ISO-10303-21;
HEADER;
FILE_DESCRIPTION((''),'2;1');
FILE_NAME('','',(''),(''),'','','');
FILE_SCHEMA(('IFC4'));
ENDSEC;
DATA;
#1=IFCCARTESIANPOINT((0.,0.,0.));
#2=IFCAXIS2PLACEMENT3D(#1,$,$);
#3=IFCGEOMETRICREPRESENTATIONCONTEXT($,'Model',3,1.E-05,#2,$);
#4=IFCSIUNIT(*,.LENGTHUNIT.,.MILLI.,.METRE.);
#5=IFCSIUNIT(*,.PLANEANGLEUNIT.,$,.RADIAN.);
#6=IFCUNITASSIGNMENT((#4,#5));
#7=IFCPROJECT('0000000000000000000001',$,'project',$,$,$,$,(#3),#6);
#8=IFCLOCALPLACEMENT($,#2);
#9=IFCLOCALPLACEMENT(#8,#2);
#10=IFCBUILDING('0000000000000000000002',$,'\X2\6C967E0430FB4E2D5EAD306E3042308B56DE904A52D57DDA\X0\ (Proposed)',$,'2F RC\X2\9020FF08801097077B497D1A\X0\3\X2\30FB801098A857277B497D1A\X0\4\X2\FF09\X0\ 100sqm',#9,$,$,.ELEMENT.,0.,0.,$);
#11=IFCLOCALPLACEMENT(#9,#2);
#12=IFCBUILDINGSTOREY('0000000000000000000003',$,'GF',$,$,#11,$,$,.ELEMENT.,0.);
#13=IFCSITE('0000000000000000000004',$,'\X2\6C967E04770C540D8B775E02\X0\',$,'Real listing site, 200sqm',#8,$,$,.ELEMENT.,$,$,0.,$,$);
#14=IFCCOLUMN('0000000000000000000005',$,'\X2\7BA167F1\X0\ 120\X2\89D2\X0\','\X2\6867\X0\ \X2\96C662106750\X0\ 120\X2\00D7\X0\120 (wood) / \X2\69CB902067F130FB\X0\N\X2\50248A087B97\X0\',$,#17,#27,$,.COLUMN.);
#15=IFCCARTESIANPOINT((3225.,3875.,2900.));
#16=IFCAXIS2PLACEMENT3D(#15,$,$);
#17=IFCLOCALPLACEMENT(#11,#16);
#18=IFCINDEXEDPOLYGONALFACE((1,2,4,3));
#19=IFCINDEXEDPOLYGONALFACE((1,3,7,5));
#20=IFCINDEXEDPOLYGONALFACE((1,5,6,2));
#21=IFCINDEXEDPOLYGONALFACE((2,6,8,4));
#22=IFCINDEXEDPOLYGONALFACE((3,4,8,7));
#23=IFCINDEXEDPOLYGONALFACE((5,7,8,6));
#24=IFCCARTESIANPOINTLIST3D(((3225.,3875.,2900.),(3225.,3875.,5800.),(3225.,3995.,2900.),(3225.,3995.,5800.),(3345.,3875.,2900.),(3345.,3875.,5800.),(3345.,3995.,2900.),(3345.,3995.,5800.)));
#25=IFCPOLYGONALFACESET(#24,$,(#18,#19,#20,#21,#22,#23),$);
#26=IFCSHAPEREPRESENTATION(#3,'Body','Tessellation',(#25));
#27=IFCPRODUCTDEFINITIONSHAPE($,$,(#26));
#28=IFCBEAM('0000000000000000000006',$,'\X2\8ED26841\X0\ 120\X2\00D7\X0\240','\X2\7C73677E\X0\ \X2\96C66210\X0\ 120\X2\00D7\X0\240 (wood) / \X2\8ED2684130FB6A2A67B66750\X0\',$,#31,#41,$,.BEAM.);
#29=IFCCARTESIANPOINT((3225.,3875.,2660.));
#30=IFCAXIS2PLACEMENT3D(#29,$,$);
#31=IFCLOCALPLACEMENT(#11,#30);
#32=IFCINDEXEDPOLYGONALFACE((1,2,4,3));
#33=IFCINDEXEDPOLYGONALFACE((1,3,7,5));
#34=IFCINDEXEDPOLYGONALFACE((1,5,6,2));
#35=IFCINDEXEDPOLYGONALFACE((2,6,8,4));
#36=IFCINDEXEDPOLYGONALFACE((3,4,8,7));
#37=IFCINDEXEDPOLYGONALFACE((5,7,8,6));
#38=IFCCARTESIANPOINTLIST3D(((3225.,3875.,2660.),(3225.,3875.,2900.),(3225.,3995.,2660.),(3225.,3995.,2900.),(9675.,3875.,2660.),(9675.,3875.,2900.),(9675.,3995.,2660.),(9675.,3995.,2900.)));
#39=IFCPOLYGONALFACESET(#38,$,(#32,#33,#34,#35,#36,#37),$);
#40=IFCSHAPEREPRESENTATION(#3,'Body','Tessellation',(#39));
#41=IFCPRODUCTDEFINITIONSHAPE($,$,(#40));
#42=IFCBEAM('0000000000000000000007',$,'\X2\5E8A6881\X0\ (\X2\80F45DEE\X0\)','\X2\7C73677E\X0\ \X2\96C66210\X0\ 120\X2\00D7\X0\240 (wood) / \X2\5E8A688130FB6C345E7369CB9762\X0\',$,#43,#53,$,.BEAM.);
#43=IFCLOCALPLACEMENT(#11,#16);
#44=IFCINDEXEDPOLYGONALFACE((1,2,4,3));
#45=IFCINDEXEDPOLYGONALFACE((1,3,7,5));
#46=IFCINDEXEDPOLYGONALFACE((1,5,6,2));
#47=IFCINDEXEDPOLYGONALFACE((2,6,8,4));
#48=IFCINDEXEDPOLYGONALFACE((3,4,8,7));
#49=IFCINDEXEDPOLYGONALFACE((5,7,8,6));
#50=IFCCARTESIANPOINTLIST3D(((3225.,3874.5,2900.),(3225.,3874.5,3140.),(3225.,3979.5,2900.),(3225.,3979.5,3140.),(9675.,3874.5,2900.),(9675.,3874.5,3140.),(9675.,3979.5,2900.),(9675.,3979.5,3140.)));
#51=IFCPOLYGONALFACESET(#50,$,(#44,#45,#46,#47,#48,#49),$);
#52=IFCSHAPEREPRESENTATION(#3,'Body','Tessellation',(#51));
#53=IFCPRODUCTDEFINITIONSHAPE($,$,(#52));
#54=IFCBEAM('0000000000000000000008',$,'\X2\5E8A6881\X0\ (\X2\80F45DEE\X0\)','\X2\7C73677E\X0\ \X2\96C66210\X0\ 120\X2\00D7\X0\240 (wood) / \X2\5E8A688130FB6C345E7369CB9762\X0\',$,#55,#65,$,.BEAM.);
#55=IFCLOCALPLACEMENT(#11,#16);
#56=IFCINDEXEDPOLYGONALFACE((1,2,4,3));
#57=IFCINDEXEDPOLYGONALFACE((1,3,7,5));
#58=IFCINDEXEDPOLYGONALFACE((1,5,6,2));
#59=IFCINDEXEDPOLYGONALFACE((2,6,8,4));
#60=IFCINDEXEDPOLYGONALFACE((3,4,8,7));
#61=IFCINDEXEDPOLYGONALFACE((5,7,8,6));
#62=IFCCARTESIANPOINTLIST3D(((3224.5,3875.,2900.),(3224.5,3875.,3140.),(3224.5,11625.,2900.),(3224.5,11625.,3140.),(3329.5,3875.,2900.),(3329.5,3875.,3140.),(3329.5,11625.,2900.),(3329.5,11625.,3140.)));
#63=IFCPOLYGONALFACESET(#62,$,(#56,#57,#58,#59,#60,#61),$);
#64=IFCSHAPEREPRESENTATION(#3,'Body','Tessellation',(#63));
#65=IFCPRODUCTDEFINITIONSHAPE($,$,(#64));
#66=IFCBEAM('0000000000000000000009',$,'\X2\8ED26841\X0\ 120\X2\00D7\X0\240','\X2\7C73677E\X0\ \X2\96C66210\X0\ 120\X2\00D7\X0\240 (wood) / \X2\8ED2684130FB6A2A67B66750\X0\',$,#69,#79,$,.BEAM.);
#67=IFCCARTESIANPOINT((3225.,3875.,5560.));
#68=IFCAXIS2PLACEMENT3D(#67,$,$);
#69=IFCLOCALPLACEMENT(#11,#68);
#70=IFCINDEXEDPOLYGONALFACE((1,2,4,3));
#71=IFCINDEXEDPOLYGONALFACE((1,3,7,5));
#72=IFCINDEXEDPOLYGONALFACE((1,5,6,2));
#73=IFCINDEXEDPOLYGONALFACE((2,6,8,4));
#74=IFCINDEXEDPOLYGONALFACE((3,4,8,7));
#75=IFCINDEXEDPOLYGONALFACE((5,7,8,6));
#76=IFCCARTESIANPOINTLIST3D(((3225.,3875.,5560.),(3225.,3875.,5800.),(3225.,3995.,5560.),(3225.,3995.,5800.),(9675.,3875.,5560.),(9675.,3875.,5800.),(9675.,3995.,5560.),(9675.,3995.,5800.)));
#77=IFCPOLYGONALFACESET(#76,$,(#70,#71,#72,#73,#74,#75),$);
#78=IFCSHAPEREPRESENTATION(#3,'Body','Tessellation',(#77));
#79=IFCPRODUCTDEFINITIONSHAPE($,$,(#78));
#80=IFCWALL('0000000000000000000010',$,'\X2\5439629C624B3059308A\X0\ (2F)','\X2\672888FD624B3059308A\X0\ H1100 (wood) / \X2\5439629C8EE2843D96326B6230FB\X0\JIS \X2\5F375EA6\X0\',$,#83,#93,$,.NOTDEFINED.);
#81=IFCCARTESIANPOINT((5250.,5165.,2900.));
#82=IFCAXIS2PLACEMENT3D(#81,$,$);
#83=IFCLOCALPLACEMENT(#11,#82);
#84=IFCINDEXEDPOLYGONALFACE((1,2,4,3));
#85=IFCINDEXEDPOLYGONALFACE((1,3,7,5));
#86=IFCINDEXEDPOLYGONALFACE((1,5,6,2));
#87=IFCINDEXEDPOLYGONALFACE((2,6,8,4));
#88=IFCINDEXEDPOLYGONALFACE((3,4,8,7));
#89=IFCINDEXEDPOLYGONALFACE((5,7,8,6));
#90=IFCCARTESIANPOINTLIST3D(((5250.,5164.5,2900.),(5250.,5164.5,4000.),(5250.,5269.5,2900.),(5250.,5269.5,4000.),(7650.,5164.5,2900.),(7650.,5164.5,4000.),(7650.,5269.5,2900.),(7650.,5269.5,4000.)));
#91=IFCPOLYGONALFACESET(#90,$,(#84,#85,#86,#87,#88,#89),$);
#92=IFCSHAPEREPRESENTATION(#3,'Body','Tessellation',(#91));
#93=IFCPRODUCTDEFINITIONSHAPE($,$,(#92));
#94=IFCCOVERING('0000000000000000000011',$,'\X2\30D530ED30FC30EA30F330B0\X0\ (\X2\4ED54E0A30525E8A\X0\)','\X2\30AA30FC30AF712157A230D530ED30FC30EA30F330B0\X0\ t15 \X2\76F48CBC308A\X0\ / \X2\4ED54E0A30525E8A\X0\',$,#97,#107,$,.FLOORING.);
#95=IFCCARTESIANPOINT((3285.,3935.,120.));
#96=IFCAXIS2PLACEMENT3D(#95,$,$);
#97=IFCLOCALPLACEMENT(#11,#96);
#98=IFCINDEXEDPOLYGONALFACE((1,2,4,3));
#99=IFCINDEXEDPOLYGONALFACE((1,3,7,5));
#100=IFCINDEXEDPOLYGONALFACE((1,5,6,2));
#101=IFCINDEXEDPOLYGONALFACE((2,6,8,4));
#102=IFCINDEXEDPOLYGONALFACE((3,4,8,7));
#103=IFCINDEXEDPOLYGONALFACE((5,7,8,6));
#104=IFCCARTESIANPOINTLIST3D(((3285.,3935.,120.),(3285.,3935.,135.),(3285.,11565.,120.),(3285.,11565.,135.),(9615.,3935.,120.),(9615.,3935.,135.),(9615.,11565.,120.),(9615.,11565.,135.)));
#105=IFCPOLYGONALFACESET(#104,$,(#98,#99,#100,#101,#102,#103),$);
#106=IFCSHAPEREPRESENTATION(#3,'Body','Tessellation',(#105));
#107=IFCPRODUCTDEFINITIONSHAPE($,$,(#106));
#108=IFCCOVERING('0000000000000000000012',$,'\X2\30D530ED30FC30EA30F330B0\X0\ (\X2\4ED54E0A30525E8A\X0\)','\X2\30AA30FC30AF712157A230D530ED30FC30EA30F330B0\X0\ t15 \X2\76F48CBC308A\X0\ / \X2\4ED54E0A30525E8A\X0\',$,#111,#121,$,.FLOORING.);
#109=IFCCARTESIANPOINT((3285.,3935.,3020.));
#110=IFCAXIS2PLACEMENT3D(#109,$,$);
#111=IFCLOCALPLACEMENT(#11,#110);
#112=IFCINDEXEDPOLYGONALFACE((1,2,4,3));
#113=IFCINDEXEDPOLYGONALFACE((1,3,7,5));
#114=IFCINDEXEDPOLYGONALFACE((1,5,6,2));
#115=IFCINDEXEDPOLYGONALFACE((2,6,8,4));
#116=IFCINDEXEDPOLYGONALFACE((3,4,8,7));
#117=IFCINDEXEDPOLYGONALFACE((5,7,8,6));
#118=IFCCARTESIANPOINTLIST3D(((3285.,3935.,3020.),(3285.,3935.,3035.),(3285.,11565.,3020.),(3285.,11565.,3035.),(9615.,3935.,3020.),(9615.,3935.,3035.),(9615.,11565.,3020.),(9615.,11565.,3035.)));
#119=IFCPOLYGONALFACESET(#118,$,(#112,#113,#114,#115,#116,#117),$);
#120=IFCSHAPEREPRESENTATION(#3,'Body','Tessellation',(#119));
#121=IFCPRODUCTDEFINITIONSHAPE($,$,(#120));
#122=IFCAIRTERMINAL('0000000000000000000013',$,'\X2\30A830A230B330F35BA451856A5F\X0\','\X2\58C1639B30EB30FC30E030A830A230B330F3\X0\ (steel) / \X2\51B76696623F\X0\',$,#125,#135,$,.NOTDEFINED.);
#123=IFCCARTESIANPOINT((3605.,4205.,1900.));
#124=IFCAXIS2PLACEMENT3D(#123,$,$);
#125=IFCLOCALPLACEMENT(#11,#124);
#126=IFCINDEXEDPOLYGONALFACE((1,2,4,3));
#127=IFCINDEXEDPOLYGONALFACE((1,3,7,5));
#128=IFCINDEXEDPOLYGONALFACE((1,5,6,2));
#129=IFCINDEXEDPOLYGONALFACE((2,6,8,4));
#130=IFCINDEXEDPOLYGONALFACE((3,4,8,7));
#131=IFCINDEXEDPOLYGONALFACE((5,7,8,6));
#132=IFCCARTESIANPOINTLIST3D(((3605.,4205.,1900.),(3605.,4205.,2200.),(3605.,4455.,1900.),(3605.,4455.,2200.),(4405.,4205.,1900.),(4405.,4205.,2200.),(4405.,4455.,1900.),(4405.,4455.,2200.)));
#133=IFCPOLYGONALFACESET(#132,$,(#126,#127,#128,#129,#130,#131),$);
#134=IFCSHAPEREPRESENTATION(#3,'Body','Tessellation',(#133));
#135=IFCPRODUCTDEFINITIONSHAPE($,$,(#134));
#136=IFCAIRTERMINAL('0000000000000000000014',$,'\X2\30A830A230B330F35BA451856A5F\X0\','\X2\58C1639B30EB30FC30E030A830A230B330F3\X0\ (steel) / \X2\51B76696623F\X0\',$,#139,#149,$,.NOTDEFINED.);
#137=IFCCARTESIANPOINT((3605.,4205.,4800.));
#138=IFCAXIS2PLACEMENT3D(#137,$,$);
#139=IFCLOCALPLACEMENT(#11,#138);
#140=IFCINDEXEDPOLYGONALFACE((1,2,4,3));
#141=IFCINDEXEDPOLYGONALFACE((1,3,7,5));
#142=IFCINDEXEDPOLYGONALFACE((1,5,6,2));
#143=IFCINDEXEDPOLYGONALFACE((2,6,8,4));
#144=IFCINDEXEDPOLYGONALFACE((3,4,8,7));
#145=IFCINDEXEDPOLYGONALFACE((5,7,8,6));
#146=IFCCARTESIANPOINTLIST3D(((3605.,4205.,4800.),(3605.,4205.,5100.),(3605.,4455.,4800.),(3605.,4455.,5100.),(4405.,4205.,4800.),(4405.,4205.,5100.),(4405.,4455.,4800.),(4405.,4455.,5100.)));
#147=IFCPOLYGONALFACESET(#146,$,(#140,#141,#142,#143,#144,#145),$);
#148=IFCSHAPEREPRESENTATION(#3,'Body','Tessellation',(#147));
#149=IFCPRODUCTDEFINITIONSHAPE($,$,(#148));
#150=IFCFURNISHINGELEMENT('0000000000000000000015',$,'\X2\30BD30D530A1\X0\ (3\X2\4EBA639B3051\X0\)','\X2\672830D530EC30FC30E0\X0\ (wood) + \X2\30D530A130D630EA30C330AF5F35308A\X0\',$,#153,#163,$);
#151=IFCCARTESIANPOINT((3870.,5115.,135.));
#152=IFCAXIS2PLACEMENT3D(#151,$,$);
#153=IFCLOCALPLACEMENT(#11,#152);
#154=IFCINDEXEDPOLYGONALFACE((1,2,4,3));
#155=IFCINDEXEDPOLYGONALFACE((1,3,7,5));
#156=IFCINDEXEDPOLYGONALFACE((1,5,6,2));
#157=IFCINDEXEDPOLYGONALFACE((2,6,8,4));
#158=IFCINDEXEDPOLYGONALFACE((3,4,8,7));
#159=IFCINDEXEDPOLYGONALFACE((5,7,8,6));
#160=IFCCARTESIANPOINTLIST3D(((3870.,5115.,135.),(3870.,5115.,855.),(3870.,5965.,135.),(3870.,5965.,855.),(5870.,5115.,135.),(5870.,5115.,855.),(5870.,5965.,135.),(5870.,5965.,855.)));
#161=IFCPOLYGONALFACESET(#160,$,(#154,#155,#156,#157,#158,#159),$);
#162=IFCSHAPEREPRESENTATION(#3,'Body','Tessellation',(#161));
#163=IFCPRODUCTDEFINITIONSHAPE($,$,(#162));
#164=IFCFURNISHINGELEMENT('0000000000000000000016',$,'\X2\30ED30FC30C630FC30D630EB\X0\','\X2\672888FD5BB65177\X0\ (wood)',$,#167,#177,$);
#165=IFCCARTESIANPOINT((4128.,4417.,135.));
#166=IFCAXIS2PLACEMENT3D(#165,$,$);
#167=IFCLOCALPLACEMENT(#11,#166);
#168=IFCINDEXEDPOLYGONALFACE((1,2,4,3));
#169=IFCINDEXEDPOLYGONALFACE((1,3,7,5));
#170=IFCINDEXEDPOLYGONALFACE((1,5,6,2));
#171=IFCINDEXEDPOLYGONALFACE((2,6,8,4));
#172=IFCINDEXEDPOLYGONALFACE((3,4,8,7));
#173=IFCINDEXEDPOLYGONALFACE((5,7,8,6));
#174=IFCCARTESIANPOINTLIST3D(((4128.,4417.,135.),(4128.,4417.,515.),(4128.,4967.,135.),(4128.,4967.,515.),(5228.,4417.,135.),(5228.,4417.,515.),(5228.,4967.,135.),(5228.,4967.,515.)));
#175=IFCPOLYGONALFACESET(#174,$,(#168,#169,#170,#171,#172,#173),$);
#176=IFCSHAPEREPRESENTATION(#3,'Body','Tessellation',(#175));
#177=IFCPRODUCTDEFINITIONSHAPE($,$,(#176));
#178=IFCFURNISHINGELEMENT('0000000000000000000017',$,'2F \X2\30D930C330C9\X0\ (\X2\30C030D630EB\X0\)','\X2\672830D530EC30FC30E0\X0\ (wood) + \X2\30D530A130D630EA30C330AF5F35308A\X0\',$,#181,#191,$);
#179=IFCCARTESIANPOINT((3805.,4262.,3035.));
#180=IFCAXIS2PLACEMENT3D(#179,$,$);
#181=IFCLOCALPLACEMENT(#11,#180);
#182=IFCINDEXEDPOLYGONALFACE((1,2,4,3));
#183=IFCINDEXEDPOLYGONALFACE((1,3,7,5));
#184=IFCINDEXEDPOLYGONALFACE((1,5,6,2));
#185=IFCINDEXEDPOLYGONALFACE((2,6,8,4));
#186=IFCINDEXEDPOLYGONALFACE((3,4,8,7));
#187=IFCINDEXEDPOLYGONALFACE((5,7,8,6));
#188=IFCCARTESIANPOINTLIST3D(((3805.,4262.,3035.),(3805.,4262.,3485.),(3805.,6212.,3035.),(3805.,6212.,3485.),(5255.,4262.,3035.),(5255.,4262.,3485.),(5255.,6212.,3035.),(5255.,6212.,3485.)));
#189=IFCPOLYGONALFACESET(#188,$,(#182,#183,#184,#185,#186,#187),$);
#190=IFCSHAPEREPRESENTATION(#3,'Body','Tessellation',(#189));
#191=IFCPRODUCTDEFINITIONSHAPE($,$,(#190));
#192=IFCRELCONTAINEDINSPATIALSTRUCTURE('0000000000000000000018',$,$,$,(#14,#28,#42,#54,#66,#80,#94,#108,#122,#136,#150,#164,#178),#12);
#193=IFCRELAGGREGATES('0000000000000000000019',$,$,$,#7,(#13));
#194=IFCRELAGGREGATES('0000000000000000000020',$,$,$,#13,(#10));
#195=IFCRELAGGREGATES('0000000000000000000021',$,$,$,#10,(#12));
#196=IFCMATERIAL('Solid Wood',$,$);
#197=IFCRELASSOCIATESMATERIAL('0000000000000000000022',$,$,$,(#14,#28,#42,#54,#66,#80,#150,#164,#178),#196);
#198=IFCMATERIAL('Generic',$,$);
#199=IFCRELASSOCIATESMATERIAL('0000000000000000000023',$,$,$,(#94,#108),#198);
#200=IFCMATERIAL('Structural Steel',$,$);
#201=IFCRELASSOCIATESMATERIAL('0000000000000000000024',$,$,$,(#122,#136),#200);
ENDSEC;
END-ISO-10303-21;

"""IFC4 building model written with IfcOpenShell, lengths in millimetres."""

from ifc_helpers import new_model, si_unit, frame, frame_2d, origin, place, context, project, spatial, rectangle, extrude, material, element, save


model = new_model("IFC4")

# Units and contexts
model_context = context("Model", 3, precision=1e-05, world=origin())
ifc_project = project(units=[si_unit("LENGTHUNIT", "METRE", prefix="MILLI"), si_unit("PLANEANGLEUNIT", "RADIAN")], contexts=[model_context])

# Site, building, storey
site_placement = place(None, origin())
site = spatial("IfcSite", under=ifc_project, at=site_placement, Name="沖縄県名護市", ObjectType="Real listing site, 200sqm", CompositionType="ELEMENT", RefElevation=0.0)
building_placement = place(site_placement, origin())
building = spatial("IfcBuilding", under=site, at=building_placement, Name="沖縄・中庭のある回遊動線 (Proposed)", ObjectType="2F RC造（耐震等級3・耐風圧等級4） 100sqm", CompositionType="ELEMENT", ElevationOfRefHeight=0.0, ElevationOfTerrain=0.0)
storey_placement = place(building_placement, origin())
storey = spatial("IfcBuildingStorey", under=building, at=storey_placement, Name="GF", CompositionType="ELEMENT", Elevation=0.0)

# Column
ifc_material_1 = material(Name="Solid Wood")
column_placement = place(storey_placement, frame((3225.0, 3875.0, 2900.0)))
element("IfcColumn", 1, at=column_placement, inside=storey, material=ifc_material_1, Name="管柱 120角", Description="桧 集成材 120×120 (wood) / 構造柱・N値計算", PredefinedType="COLUMN", context=model_context, shape_type="SweptSolid", body=[
    extrude(rectangle(XDim=120.0, YDim=120.0, at=frame_2d((60.0, 60.0))), frame((3225.0, 3875.0, 2900.0)), (0.0, 0.0, 1.0), 2900.0),
])

# Beams
beam_1_placement = place(storey_placement, frame((3225.0, 3875.0, 2660.0)))
element("IfcBeam", 2, at=beam_1_placement, inside=storey, material=ifc_material_1, Name="軒桁 120×240", Description="米松 集成 120×240 (wood) / 軒桁・横架材", PredefinedType="BEAM", context=model_context, shape_type="SweptSolid", body=[
    extrude(rectangle(XDim=6450.0, YDim=120.0, at=frame_2d((3225.0, 60.0))), frame((3225.0, 3875.0, 2660.0)), (0.0, 0.0, 1.0), 240.0),
])
beam_2_placement = place(storey_placement, frame((3225.0, 3875.0, 2900.0)))
element("IfcBeam", 3, at=beam_2_placement, inside=storey, material=ifc_material_1, Name="床梁 (胴差)", Description="米松 集成 120×240 (wood) / 床梁・水平構面", PredefinedType="BEAM", context=model_context, shape_type="SweptSolid", body=[
    extrude(rectangle(XDim=6450.0, YDim=105.0, at=frame_2d((3225.0, 52.0))), frame((3225.0, 3875.0, 2900.0)), (0.0, 0.0, 1.0), 240.0),
])
beam_3_placement = place(storey_placement, frame((3225.0, 3875.0, 2900.0)))
element("IfcBeam", 4, at=beam_3_placement, inside=storey, material=ifc_material_1, Name="床梁 (胴差)", Description="米松 集成 120×240 (wood) / 床梁・水平構面", PredefinedType="BEAM", context=model_context, shape_type="SweptSolid", body=[
    extrude(rectangle(XDim=105.0, YDim=7750.0, at=frame_2d((52.0, 3875.0))), frame((3225.0, 3875.0, 2900.0)), (0.0, 0.0, 1.0), 240.0),
])
beam_4_placement = place(storey_placement, frame((3225.0, 3875.0, 5560.0)))
element("IfcBeam", 5, at=beam_4_placement, inside=storey, material=ifc_material_1, Name="軒桁 120×240", Description="米松 集成 120×240 (wood) / 軒桁・横架材", PredefinedType="BEAM", context=model_context, shape_type="SweptSolid", body=[
    extrude(rectangle(XDim=6450.0, YDim=120.0, at=frame_2d((3225.0, 60.0))), frame((3225.0, 3875.0, 5560.0)), (0.0, 0.0, 1.0), 240.0),
])

# Wall
wall_placement = place(storey_placement, frame((5250.0, 5165.0, 2900.0)))
element("IfcWall", 6, at=wall_placement, inside=storey, material=ifc_material_1, Name="吹抜手すり (2F)", Description="木製手すり H1100 (wood) / 吹抜転落防止・JIS 強度", PredefinedType="NOTDEFINED", context=model_context, shape_type="SweptSolid", body=[
    extrude(rectangle(XDim=2400.0, YDim=105.0, at=frame_2d((1200.0, 52.0))), frame((5250.0, 5165.0, 2900.0)), (0.0, 0.0, 1.0), 1100.0),
])

# Coverings
ifc_material_2 = material(Name="Generic")
covering_1_placement = place(storey_placement, frame((3285.0, 3935.0, 120.0)))
element("IfcCovering", 7, at=covering_1_placement, inside=storey, material=ifc_material_2, Name="フローリング (仕上げ床)", Description="オーク無垢フローリング t15 直貼り / 仕上げ床", PredefinedType="FLOORING", context=model_context, shape_type="SweptSolid", body=[
    extrude(rectangle(XDim=6330.0, YDim=7630.0, at=frame_2d((3165.0, 3815.0))), frame((3285.0, 3935.0, 120.0)), (0.0, 0.0, 1.0), 15.0),
])
covering_2_placement = place(storey_placement, frame((3285.0, 3935.0, 3020.0)))
element("IfcCovering", 8, at=covering_2_placement, inside=storey, material=ifc_material_2, Name="フローリング (仕上げ床)", Description="オーク無垢フローリング t15 直貼り / 仕上げ床", PredefinedType="FLOORING", context=model_context, shape_type="SweptSolid", body=[
    extrude(rectangle(XDim=6330.0, YDim=7630.0, at=frame_2d((3165.0, 3815.0))), frame((3285.0, 3935.0, 3020.0)), (0.0, 0.0, 1.0), 15.0),
])

# Air terminals
ifc_material_3 = material(Name="Structural Steel")
air_terminal_1_placement = place(storey_placement, frame((3605.0, 4205.0, 1900.0)))
element("IfcAirTerminal", 9, at=air_terminal_1_placement, inside=storey, material=ifc_material_3, Name="エアコン室内機", Description="壁掛ルームエアコン (steel) / 冷暖房", PredefinedType="NOTDEFINED", context=model_context, shape_type="SweptSolid", body=[
    extrude(rectangle(XDim=800.0, YDim=250.0, at=frame_2d((400.0, 125.0))), frame((3605.0, 4205.0, 1900.0)), (0.0, 0.0, 1.0), 300.0),
])
air_terminal_2_placement = place(storey_placement, frame((3605.0, 4205.0, 4800.0)))
element("IfcAirTerminal", 10, at=air_terminal_2_placement, inside=storey, material=ifc_material_3, Name="エアコン室内機", Description="壁掛ルームエアコン (steel) / 冷暖房", PredefinedType="NOTDEFINED", context=model_context, shape_type="SweptSolid", body=[
    extrude(rectangle(XDim=800.0, YDim=250.0, at=frame_2d((400.0, 125.0))), frame((3605.0, 4205.0, 4800.0)), (0.0, 0.0, 1.0), 300.0),
])

# Furnishing elements
furnishing_1_placement = place(storey_placement, frame((3870.0, 5115.0, 135.0)))
element("IfcFurnishingElement", 11, at=furnishing_1_placement, inside=storey, material=ifc_material_1, Name="ソファ (3人掛け)", Description="木フレーム (wood) + ファブリック張り", context=model_context, shape_type="SweptSolid", body=[
    extrude(rectangle(XDim=2000.0, YDim=850.0, at=frame_2d((1000.0, 425.0))), frame((3870.0, 5115.0, 135.0)), (0.0, 0.0, 1.0), 720.0),
])
furnishing_2_placement = place(storey_placement, frame((4128.0, 4417.0, 135.0)))
element("IfcFurnishingElement", 12, at=furnishing_2_placement, inside=storey, material=ifc_material_1, Name="ローテーブル", Description="木製家具 (wood)", context=model_context, shape_type="SweptSolid", body=[
    extrude(rectangle(XDim=1100.0, YDim=550.0, at=frame_2d((550.0, 275.0))), frame((4128.0, 4417.0, 135.0)), (0.0, 0.0, 1.0), 380.0),
])
furnishing_3_placement = place(storey_placement, frame((3805.0, 4262.0, 3035.0)))
element("IfcFurnishingElement", 13, at=furnishing_3_placement, inside=storey, material=ifc_material_1, Name="2F ベッド (ダブル)", Description="木フレーム (wood) + ファブリック張り", context=model_context, shape_type="SweptSolid", body=[
    extrude(rectangle(XDim=1450.0, YDim=1950.0, at=frame_2d((725.0, 975.0))), frame((3805.0, 4262.0, 3035.0)), (0.0, 0.0, 1.0), 450.0),
])

save(model, "model.ifc")
